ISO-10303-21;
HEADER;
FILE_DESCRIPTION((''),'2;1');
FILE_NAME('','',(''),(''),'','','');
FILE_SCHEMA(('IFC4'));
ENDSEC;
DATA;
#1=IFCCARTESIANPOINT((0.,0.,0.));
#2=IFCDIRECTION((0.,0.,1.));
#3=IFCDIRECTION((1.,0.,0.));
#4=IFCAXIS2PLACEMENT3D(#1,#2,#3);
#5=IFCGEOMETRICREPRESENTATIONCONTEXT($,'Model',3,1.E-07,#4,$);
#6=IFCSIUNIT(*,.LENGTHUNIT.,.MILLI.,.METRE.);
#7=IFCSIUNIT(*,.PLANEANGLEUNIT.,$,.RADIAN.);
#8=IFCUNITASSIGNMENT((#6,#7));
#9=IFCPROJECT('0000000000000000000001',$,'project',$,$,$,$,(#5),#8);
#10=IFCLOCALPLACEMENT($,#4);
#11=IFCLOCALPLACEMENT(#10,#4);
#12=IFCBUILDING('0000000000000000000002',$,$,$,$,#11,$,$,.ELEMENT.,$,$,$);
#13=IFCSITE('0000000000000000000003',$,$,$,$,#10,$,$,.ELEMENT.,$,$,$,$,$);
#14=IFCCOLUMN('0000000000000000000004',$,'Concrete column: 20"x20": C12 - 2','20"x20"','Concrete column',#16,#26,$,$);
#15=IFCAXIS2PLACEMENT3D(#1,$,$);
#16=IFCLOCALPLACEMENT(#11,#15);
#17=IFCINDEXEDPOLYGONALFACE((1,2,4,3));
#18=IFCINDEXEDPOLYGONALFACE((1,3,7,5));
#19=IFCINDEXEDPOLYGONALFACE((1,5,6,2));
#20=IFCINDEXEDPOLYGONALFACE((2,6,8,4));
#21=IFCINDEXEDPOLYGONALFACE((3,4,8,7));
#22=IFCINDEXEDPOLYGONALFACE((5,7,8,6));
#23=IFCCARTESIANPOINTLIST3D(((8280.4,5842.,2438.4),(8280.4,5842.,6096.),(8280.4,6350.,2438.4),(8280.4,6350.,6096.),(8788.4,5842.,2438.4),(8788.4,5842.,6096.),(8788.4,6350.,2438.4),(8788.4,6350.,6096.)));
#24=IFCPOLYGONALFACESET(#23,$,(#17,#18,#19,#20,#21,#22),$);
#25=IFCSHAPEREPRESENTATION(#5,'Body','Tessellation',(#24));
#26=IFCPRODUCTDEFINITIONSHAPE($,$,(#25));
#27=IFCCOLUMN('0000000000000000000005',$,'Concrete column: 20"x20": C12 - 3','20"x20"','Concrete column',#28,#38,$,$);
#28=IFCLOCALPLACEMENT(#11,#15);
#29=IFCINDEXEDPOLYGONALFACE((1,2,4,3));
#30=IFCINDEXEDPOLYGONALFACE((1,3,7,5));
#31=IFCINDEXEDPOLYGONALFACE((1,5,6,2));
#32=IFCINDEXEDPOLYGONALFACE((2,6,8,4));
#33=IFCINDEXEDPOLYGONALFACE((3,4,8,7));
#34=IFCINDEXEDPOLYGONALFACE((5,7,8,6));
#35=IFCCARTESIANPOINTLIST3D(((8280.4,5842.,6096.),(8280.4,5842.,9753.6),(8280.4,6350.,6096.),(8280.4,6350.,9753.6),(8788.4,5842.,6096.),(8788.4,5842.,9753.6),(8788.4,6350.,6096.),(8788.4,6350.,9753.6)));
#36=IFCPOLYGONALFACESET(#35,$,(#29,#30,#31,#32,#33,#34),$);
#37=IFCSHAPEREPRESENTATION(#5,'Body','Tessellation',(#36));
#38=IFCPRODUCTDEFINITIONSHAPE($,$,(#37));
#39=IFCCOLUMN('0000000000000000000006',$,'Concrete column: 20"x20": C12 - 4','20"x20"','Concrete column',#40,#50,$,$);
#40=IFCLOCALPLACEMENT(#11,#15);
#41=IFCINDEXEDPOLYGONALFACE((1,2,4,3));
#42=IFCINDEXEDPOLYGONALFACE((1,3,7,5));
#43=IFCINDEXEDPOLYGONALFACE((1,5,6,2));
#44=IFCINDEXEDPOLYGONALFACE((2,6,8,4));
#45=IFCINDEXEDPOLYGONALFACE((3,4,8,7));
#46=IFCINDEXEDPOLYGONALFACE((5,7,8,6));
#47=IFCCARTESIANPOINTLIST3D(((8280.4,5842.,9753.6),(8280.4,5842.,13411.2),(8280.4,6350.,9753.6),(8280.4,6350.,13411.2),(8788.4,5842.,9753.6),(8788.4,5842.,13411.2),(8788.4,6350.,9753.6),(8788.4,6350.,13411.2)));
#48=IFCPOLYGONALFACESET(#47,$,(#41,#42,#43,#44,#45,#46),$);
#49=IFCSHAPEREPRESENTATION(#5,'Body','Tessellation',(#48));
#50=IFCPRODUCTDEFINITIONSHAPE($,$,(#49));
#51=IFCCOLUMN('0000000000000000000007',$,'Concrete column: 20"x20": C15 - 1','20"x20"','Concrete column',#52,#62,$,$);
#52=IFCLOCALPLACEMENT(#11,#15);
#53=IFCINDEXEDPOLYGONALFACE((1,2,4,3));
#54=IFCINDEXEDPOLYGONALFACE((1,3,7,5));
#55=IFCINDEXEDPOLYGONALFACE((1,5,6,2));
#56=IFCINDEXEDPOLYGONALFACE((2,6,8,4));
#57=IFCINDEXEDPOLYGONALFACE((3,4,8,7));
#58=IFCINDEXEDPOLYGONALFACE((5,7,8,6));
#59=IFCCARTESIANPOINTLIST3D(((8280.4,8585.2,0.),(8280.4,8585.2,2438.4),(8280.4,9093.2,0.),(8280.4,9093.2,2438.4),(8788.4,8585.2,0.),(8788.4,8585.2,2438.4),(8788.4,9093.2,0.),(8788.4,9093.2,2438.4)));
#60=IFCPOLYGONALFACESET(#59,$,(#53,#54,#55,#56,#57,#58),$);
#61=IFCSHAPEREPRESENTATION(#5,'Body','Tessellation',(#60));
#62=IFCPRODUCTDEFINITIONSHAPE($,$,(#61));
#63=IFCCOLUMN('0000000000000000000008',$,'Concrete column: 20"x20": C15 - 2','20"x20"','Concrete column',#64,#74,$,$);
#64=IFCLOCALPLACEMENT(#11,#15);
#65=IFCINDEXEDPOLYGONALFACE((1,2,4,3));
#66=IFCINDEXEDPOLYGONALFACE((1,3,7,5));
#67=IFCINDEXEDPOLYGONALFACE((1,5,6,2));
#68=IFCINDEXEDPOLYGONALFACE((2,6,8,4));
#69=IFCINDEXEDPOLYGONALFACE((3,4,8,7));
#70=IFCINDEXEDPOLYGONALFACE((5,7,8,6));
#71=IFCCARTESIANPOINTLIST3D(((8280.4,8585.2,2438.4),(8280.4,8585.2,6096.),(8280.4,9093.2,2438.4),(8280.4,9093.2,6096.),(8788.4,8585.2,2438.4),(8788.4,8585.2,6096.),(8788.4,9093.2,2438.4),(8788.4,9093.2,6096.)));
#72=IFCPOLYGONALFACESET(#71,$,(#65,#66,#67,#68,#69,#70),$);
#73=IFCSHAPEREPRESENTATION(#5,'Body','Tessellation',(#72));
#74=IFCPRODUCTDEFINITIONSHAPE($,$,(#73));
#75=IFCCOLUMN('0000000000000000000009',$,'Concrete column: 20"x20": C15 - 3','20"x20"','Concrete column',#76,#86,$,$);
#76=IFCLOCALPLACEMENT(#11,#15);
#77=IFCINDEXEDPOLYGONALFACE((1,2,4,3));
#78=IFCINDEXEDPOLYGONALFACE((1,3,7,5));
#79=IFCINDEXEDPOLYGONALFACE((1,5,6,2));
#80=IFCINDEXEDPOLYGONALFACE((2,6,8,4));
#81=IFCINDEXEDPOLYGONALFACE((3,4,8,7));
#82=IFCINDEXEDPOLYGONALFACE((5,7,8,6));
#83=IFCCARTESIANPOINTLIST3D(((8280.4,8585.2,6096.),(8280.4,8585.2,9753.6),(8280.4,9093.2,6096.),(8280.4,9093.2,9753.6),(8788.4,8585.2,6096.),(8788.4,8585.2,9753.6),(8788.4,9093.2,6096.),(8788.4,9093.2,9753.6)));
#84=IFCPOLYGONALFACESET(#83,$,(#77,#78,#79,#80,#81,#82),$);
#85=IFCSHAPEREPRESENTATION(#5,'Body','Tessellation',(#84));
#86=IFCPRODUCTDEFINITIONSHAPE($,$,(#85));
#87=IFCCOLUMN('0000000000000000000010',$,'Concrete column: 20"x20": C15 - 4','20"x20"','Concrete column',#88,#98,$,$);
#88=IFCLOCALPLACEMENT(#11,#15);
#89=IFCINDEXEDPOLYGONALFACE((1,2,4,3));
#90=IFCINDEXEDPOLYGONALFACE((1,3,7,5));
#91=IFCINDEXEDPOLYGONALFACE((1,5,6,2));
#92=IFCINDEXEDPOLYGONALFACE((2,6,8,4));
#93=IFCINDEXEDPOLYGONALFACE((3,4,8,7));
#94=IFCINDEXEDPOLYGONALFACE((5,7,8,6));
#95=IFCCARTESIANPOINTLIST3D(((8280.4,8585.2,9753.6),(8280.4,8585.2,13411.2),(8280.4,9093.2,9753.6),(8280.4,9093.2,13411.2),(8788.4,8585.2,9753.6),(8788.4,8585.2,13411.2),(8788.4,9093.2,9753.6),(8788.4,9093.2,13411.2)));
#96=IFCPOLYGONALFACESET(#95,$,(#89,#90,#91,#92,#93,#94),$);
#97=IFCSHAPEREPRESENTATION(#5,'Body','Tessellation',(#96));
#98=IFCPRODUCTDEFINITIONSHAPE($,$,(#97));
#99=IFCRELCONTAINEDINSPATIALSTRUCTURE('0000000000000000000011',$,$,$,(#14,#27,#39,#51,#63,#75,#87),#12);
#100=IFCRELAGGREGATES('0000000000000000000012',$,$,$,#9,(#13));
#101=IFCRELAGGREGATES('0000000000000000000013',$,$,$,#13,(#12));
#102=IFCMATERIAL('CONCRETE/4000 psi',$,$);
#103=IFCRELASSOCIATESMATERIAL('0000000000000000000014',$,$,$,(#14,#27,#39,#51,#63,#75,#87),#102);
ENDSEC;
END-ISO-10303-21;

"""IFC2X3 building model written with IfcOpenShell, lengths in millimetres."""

from ifc_helpers import new_model, si_unit, frame, origin_with_axes, origin_2d_with_axis, place, context, project, spatial, rectangle, extrude, material, element, save


model = new_model("IFC2X3")

# Units and contexts
model_context = context("Model", 3, precision=1e-07, world=origin_with_axes())
ifc_project = project(units=[si_unit("LENGTHUNIT", "METRE", prefix="MILLI"), si_unit("PLANEANGLEUNIT", "RADIAN")], contexts=[model_context])

# Site, building
site_placement = place(None, origin_with_axes())
site = spatial("IfcSite", under=ifc_project, at=site_placement, CompositionType="ELEMENT")
building_placement = place(site_placement, origin_with_axes())
building = spatial("IfcBuilding", under=site, at=building_placement, CompositionType="ELEMENT")

# Columns
ifc_material = material(Name="CONCRETE/4000 psi")
for number, where, z_axis, x_axis, name in (
    (1, (8534.4, 6096.0, 2438.4), (0.0, 0.0, 1.0), (1.0, 0.0, 0.0), "Concrete column: 20\"x20\": C12 - 2"),
    (2, (8534.4, 6096.0, 6096.0), (0.0, 0.0, 1.0), (1.0, 0.0, 0.0), "Concrete column: 20\"x20\": C12 - 3"),
    (3, (8534.4, 6096.0, 9753.6), (0.0, 0.0, 1.0), (1.0, 0.0, 0.0), "Concrete column: 20\"x20\": C12 - 4"),
):
    element("IfcColumn", number, at=place(building_placement, frame(where, z_axis=z_axis, x_axis=x_axis)), inside=building, material=ifc_material, Name=name, Description="20\"x20\"", ObjectType="Concrete column", context=model_context, shape_type="SweptSolid", body=[
        extrude(rectangle(XDim=508.0, YDim=508.0, at=origin_2d_with_axis()), origin_with_axes(), (0.0, 0.0, 1.0), 3657.6),
    ])
column_1_placement = place(building_placement, frame((8534.4, 8839.2, 0.0), z_axis=(0.0, 0.0, 1.0), x_axis=(1.0, 0.0, 0.0)))
element("IfcColumn", 4, at=column_1_placement, inside=building, material=ifc_material, Name="Concrete column: 20\"x20\": C15 - 1", Description="20\"x20\"", ObjectType="Concrete column", context=model_context, shape_type="SweptSolid", body=[
    extrude(rectangle(XDim=508.0, YDim=508.0, at=origin_2d_with_axis()), origin_with_axes(), (0.0, 0.0, 1.0), 2438.4),
])
for number, where, z_axis, x_axis, name in (
    (5, (8534.4, 8839.2, 2438.4), (0.0, 0.0, 1.0), (1.0, 0.0, 0.0), "Concrete column: 20\"x20\": C15 - 2"),
    (6, (8534.4, 8839.2, 6096.0), (0.0, 0.0, 1.0), (1.0, 0.0, 0.0), "Concrete column: 20\"x20\": C15 - 3"),
    (7, (8534.4, 8839.2, 9753.6), (0.0, 0.0, 1.0), (1.0, 0.0, 0.0), "Concrete column: 20\"x20\": C15 - 4"),
):
    element("IfcColumn", number, at=place(building_placement, frame(where, z_axis=z_axis, x_axis=x_axis)), inside=building, material=ifc_material, Name=name, Description="20\"x20\"", ObjectType="Concrete column", context=model_context, shape_type="SweptSolid", body=[
        extrude(rectangle(XDim=508.0, YDim=508.0, at=origin_2d_with_axis()), origin_with_axes(), (0.0, 0.0, 1.0), 3657.6),
    ])

save(model, "model.ifc")
